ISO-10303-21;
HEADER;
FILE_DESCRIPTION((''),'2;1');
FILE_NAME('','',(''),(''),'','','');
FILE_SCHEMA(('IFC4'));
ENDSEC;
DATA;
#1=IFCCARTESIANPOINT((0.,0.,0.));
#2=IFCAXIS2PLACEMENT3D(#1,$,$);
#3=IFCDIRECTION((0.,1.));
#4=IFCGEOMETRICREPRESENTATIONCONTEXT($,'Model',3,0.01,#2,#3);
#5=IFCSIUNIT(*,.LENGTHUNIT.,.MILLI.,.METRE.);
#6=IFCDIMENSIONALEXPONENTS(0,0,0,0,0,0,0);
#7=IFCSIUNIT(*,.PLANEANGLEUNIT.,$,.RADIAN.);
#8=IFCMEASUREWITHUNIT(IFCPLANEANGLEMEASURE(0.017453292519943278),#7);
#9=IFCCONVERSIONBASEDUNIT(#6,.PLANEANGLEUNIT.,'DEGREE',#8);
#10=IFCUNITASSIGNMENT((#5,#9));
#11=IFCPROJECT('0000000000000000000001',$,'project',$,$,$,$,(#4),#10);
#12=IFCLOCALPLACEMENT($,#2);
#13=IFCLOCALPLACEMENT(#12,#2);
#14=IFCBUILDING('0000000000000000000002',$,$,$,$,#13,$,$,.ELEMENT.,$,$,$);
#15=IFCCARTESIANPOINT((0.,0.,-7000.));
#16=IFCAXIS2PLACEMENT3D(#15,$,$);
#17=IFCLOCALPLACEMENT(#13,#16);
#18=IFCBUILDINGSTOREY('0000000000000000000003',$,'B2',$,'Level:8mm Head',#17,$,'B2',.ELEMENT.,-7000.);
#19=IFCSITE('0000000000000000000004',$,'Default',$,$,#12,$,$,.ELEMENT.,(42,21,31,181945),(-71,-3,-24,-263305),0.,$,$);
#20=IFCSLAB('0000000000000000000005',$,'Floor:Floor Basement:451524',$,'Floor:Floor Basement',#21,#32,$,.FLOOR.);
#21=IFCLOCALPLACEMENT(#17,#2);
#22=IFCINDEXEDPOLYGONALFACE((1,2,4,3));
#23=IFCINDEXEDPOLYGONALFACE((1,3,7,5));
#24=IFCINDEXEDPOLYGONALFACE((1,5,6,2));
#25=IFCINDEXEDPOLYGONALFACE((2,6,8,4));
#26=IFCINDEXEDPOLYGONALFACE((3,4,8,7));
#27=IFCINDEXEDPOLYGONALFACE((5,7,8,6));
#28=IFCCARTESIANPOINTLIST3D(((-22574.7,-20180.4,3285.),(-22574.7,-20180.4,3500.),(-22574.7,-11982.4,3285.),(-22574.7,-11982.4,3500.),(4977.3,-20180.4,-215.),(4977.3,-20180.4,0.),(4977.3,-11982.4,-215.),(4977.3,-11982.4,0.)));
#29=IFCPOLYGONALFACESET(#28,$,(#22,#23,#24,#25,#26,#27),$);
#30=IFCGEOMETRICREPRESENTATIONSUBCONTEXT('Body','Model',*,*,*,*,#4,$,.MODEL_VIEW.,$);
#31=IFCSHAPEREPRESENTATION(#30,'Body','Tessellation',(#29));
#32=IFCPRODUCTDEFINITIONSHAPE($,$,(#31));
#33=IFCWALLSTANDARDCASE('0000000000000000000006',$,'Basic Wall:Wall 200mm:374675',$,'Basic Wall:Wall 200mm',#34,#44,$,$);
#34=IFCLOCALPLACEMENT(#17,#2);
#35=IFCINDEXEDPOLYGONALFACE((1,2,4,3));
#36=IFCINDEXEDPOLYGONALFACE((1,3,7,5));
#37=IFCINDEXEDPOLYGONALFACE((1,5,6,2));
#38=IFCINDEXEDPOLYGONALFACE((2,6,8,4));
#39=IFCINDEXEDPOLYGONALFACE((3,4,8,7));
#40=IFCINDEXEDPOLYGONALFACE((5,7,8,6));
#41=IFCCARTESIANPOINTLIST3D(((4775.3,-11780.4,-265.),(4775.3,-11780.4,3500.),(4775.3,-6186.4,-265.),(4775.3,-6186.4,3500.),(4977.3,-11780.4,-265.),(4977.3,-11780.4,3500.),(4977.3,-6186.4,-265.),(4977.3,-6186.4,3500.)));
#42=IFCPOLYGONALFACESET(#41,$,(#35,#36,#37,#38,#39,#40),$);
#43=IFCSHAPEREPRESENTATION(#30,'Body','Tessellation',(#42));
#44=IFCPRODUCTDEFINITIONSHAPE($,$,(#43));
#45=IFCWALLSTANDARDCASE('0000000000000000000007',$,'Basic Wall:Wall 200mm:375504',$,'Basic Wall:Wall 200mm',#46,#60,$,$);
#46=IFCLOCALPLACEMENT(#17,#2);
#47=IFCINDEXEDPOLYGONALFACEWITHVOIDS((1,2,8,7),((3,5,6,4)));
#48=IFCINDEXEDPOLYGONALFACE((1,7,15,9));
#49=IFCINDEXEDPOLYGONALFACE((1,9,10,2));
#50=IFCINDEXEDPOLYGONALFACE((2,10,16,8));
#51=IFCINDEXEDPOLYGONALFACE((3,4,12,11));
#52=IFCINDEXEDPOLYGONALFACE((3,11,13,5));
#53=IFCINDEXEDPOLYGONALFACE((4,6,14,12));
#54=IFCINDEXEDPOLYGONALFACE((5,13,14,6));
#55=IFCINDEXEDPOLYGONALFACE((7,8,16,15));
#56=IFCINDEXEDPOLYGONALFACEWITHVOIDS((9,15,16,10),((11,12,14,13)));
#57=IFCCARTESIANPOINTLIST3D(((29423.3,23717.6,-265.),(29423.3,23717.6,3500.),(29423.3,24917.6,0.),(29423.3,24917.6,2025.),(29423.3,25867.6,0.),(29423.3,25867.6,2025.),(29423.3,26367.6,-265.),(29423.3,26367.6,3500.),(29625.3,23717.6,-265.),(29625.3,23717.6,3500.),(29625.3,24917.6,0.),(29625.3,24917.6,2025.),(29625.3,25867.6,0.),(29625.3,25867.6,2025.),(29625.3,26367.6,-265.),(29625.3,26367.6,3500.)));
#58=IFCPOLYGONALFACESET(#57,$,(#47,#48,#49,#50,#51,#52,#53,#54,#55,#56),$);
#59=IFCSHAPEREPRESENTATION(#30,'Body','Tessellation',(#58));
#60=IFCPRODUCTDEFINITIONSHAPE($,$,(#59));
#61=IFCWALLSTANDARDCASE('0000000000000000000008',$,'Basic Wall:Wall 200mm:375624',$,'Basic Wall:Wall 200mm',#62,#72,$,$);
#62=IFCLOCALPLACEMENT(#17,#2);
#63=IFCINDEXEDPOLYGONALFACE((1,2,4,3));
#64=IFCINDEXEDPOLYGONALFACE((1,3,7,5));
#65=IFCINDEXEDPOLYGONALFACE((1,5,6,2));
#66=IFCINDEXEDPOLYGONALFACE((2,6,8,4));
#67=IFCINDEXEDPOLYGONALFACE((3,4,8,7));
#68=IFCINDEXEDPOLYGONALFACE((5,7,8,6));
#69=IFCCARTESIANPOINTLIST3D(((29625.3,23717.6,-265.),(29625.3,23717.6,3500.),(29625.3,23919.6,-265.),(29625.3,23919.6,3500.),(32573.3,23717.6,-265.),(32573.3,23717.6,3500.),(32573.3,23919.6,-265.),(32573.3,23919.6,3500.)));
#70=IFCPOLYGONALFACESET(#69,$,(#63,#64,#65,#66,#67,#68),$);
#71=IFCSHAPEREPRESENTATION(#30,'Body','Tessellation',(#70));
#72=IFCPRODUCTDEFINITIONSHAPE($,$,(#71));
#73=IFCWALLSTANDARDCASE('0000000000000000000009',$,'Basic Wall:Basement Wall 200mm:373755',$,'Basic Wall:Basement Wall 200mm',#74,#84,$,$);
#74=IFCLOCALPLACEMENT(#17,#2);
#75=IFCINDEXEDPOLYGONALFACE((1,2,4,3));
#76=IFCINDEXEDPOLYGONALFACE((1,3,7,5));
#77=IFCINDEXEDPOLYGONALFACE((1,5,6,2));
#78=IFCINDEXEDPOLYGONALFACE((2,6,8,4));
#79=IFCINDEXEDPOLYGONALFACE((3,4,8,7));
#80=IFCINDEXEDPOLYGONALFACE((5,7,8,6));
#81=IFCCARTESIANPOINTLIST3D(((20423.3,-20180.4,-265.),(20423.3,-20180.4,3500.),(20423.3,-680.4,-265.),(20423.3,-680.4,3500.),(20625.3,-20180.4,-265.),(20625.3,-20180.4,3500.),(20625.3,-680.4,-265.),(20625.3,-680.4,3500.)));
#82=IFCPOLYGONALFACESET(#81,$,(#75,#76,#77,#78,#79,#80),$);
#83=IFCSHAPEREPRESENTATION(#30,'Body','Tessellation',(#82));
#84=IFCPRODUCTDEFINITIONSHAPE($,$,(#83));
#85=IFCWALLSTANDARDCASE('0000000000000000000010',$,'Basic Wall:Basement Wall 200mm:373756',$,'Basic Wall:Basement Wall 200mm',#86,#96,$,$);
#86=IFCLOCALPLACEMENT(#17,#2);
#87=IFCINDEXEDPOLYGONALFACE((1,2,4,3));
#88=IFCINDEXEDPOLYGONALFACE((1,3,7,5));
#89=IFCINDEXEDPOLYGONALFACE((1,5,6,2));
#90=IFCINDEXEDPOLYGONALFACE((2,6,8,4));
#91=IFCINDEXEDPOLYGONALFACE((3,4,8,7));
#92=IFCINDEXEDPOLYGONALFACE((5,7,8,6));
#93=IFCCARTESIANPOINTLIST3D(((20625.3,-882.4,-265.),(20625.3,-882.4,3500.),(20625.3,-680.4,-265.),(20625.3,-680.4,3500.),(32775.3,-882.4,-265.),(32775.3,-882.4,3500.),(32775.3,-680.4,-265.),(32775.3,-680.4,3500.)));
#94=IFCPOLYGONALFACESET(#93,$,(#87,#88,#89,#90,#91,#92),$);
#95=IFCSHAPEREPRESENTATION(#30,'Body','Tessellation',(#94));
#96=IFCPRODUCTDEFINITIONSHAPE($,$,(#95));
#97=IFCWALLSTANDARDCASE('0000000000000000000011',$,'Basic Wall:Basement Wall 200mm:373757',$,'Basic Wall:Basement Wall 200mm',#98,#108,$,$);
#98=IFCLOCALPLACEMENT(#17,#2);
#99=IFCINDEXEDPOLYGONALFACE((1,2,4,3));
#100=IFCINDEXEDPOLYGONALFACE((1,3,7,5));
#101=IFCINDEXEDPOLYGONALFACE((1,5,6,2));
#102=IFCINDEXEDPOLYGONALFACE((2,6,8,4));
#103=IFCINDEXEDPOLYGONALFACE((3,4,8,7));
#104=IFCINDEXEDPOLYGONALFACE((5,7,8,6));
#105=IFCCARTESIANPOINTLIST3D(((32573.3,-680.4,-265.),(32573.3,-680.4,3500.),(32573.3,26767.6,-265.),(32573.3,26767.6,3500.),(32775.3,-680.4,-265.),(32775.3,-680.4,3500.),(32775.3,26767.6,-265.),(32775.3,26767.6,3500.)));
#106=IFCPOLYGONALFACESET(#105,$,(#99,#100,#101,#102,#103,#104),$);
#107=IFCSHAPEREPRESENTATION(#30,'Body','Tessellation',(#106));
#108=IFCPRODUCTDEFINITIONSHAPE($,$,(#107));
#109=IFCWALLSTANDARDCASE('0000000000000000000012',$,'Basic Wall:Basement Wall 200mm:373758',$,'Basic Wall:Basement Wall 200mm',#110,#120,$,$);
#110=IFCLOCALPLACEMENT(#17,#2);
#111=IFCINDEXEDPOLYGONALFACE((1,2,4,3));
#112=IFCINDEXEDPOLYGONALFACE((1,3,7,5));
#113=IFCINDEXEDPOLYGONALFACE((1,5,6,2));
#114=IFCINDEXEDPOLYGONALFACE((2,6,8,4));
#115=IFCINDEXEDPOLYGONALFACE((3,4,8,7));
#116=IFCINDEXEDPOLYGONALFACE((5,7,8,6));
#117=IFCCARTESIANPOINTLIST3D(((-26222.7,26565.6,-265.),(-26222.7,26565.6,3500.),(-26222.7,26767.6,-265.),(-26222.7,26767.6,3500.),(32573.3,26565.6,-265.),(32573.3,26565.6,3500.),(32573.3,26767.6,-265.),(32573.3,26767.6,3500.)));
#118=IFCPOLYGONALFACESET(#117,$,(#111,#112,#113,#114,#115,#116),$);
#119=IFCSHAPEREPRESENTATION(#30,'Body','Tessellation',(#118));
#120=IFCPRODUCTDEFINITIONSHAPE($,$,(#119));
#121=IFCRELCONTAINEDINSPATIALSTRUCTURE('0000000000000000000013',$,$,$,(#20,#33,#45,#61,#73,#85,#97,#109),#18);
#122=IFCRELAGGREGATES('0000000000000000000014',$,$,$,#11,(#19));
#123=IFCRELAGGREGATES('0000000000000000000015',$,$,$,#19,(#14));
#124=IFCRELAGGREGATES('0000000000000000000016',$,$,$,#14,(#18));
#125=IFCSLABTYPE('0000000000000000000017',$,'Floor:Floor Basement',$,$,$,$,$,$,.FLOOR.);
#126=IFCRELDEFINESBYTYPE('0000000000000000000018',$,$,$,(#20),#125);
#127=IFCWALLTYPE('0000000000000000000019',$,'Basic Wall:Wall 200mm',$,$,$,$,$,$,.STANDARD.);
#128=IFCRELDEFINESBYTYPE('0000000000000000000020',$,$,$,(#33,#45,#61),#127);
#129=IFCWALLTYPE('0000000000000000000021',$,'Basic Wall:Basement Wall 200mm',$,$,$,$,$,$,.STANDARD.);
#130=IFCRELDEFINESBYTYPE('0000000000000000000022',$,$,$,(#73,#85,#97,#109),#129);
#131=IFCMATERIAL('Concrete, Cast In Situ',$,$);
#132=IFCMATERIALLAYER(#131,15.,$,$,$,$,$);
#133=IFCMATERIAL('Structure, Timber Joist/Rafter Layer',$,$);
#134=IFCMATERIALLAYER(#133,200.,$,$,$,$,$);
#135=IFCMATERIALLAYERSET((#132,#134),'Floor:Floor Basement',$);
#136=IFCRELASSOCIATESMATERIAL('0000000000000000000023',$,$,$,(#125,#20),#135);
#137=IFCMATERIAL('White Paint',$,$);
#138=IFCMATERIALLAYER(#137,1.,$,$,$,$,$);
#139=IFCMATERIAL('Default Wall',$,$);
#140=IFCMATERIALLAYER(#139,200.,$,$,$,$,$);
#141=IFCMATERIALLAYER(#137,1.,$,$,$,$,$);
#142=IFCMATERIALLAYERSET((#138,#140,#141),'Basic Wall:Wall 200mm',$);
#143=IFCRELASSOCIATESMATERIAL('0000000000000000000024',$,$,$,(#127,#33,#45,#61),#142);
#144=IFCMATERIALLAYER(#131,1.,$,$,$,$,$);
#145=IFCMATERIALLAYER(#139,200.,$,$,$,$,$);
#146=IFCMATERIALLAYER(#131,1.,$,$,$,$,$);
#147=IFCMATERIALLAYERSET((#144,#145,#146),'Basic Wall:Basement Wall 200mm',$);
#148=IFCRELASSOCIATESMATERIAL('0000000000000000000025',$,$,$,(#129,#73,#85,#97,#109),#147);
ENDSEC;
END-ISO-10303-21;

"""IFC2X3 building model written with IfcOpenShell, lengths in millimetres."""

from ifc_helpers import new_model, entity, si_unit, converted_unit, direction, frame, frame_2d, origin, place, context, subcontext, project, spatial, rectangle, extrude, clip, halfspace, material, layer, layer_set, layer_usage, type_object, element, save


model = new_model("IFC2X3")

# Units and contexts
model_context = context("Model", 3, precision=0.01, world=origin(), true_north=direction((0.0, 1.0)))
body_context = subcontext(model_context, "Body", "Model", "MODEL_VIEW")
ifc_project = project(units=[si_unit("LENGTHUNIT", "METRE", prefix="MILLI"), converted_unit("PLANEANGLEUNIT", "DEGREE", entity("IfcPlaneAngleMeasure", 0.017453292519943278), si_unit("PLANEANGLEUNIT", "RADIAN"), dimensions=[0, 0, 0, 0, 0, 0, 0])], contexts=[model_context])

# Site, building, storey
site_placement = place(None, origin())
site = spatial("IfcSite", under=ifc_project, at=site_placement, Name="Default", CompositionType="ELEMENT", RefLatitude=(42, 21, 31, 181945), RefLongitude=(-71, -3, -24, -263305), RefElevation=0.0)
building_placement = place(site_placement, origin())
building = spatial("IfcBuilding", under=site, at=building_placement, CompositionType="ELEMENT")
storey_placement = place(building_placement, frame((0.0, 0.0, -7000.0)))
storey = spatial("IfcBuildingStorey", under=building, at=storey_placement, Name="B2", ObjectType="Level:8mm Head", LongName="B2", CompositionType="ELEMENT", Elevation=-7000.0)

# Shared definitions
ifc_material_1 = material(Name="White Paint")

# Slab
ifc_material_2 = material(Name="Concrete, Cast In Situ")
ifc_layer_1 = layer(ifc_material_2, 15.0)
ifc_material_3 = material(Name="Structure, Timber Joist/Rafter Layer")
ifc_layer_2 = layer(ifc_material_3, 200.0)
ifc_layer_set_1 = layer_set([ifc_layer_1, ifc_layer_2], Name="Floor:Floor Basement")
ifc_layer_usage_1 = layer_usage(ifc_layer_set_1, "AXIS3", "POSITIVE", 0.0)
slab_type = type_object("IfcSlabType", Name="Floor:Floor Basement", PredefinedType="FLOOR", material=ifc_layer_set_1)
slab_placement = place(storey_placement, origin())
element("IfcSlab", 1, at=slab_placement, inside=storey, type_object=slab_type, material=ifc_layer_usage_1, Name="Floor:Floor Basement:451524", ObjectType="Floor:Floor Basement", PredefinedType="FLOOR", context=body_context, shape_type="SweptSolid", body=[
    clip(clip(extrude(rectangle(XDim=27773.4, YDim=8198.0, at=frame_2d((0.0, 0.0), x_axis=(0.0, 1.0))), frame((-8798.7, -16081.4, 1750.0), z_axis=(-0.12602, 0.0, -0.992028), x_axis=(0.0, 1.0, 0.0)), (0.0, 0.12602, 0.992028), 216.7), halfspace(frame((-8798.7, -16081.4, 1535.0), z_axis=(-0.12602, 0.0, -0.992028), x_axis=(0.0, -1.0, 0.0)), False)), halfspace(frame((-8798.7, -16081.4, 1750.0), z_axis=(0.12602, 0.0, 0.992028), x_axis=(0.0, -1.0, 0.0)), False)),
])

# Wall
ifc_layer_3 = layer(ifc_material_1, 1.0)
ifc_material_4 = material(Name="Default Wall")
ifc_layer_4 = layer(ifc_material_4, 200.0)
ifc_layer_5 = layer(ifc_material_1, 1.0)
ifc_layer_set_2 = layer_set([ifc_layer_3, ifc_layer_4, ifc_layer_5], Name="Basic Wall:Wall 200mm")
ifc_layer_usage_2 = layer_usage(ifc_layer_set_2, "AXIS2", "NEGATIVE", 101.0)
wall_type_1 = type_object("IfcWallType", Name="Basic Wall:Wall 200mm", PredefinedType="STANDARD", material=ifc_layer_set_2)
wall_1_placement = place(storey_placement, frame((4876.3, -6186.4, -265.0), z_axis=(0.0, 0.0, 1.0), x_axis=(0.0, -1.0, 0.0)))
element("IfcWallStandardCase", 2, at=wall_1_placement, inside=storey, type_object=wall_type_1, material=ifc_layer_usage_2, Name="Basic Wall:Wall 200mm:374675", ObjectType="Basic Wall:Wall 200mm", context=body_context, shape_type="SweptSolid", body=[
    extrude(rectangle(XDim=5594.0, YDim=202.0, at=frame_2d((2797.0, 0.0), x_axis=(-1.0, 0.0))), origin(), (0.0, 0.0, 1.0), 3765.0),
])

# Wall, openings
ifc_layer_usage_3 = layer_usage(ifc_layer_set_2, "AXIS2", "NEGATIVE", 101.0)
wall_2_placement = place(storey_placement, frame((29524.3, 26367.6, -265.0), z_axis=(0.0, 0.0, 1.0), x_axis=(0.0, -1.0, 0.0)))
wall_2 = element("IfcWallStandardCase", 3, at=wall_2_placement, inside=storey, type_object=wall_type_1, material=ifc_layer_usage_3, Name="Basic Wall:Wall 200mm:375504", ObjectType="Basic Wall:Wall 200mm", context=body_context, shape_type="SweptSolid", body=[
    extrude(rectangle(XDim=2650.0, YDim=202.0, at=frame_2d((1325.0, 0.0), x_axis=(-1.0, 0.0))), origin(), (0.0, 0.0, 1.0), 3765.0),
])
opening_1_placement = place(wall_2_placement, origin())
element("IfcOpeningElement", 4, at=opening_1_placement, cuts=wall_2, ObjectType="Opening", context=body_context, shape_type="SweptSolid", body=[
    extrude(rectangle(XDim=2025.0, YDim=950.0, at=frame_2d((0.0, 0.0), x_axis=(0.0, 1.0))), frame((975.0, -1625.0, 4777.5), z_axis=(0.0, 1.0, 0.0), x_axis=(-1.0, 0.0, 0.0)), (0.0, 0.0, 1.0), 3048.0),
])
opening_2_placement = place(wall_2_placement, frame((500.0, -101.0, 265.0)))
element("IfcOpeningElement", 5, at=opening_2_placement, cuts=wall_2, ObjectType="Opening", context=body_context, shape_type="SweptSolid", body=[
    extrude(rectangle(XDim=2025.0, YDim=950.0, at=frame_2d((1012.5, 475.0), x_axis=(1.0, 0.0))), frame((0.0, 0.0, 0.0), z_axis=(0.0, 1.0, 0.0), x_axis=(0.0, 0.0, 1.0)), (0.0, 0.0, 1.0), 202.0),
])

# Walls
ifc_layer_usage_4 = layer_usage(ifc_layer_set_2, "AXIS2", "POSITIVE", -101.0)
wall_3_placement = place(storey_placement, frame((29625.3, 23818.6, -265.0)))
element("IfcWallStandardCase", 6, at=wall_3_placement, inside=storey, type_object=wall_type_1, material=ifc_layer_usage_4, Name="Basic Wall:Wall 200mm:375624", ObjectType="Basic Wall:Wall 200mm", context=body_context, shape_type="SweptSolid", body=[
    extrude(rectangle(XDim=2948.0, YDim=202.0, at=frame_2d((1474.0, 0.0), x_axis=(-1.0, 0.0))), origin(), (0.0, 0.0, 1.0), 3765.0),
])
ifc_layer_6 = layer(ifc_material_2, 1.0)
ifc_layer_7 = layer(ifc_material_4, 200.0)
ifc_layer_8 = layer(ifc_material_2, 1.0)
ifc_layer_set_3 = layer_set([ifc_layer_6, ifc_layer_7, ifc_layer_8], Name="Basic Wall:Basement Wall 200mm")
ifc_layer_usage_5 = layer_usage(ifc_layer_set_3, "AXIS2", "POSITIVE", -101.0)
wall_type_2 = type_object("IfcWallType", Name="Basic Wall:Basement Wall 200mm", PredefinedType="STANDARD", material=ifc_layer_set_3)
wall_4_placement = place(storey_placement, frame((20524.3, -20180.4, -265.0), z_axis=(0.0, 0.0, 1.0), x_axis=(0.0, 1.0, 0.0)))
element("IfcWallStandardCase", 7, at=wall_4_placement, inside=storey, type_object=wall_type_2, material=ifc_layer_usage_5, Name="Basic Wall:Basement Wall 200mm:373755", ObjectType="Basic Wall:Basement Wall 200mm", context=body_context, shape_type="SweptSolid", body=[
    extrude(rectangle(XDim=19500.0, YDim=202.0, at=frame_2d((9750.0, 0.0), x_axis=(-1.0, 0.0))), origin(), (0.0, 0.0, 1.0), 3765.0),
])
ifc_layer_usage_6 = layer_usage(ifc_layer_set_3, "AXIS2", "POSITIVE", -101.0)
wall_5_placement = place(storey_placement, frame((20625.3, -781.4, -265.0)))
element("IfcWallStandardCase", 8, at=wall_5_placement, inside=storey, type_object=wall_type_2, material=ifc_layer_usage_6, Name="Basic Wall:Basement Wall 200mm:373756", ObjectType="Basic Wall:Basement Wall 200mm", context=body_context, shape_type="SweptSolid", body=[
    extrude(rectangle(XDim=12150.0, YDim=202.0, at=frame_2d((6075.0, 0.0), x_axis=(-1.0, 0.0))), origin(), (0.0, 0.0, 1.0), 3765.0),
])
ifc_layer_usage_7 = layer_usage(ifc_layer_set_3, "AXIS2", "POSITIVE", -101.0)
wall_6_placement = place(storey_placement, frame((32674.3, -680.4, -265.0), z_axis=(0.0, 0.0, 1.0), x_axis=(0.0, 1.0, 0.0)))
element("IfcWallStandardCase", 9, at=wall_6_placement, inside=storey, type_object=wall_type_2, material=ifc_layer_usage_7, Name="Basic Wall:Basement Wall 200mm:373757", ObjectType="Basic Wall:Basement Wall 200mm", context=body_context, shape_type="SweptSolid", body=[
    extrude(rectangle(XDim=27448.0, YDim=202.0, at=frame_2d((13724.0, 0.0), x_axis=(-1.0, 0.0))), origin(), (0.0, 0.0, 1.0), 3765.0),
])
ifc_layer_usage_8 = layer_usage(ifc_layer_set_3, "AXIS2", "POSITIVE", -101.0)
wall_7_placement = place(storey_placement, frame((32573.3, 26666.6, -265.0), z_axis=(0.0, 0.0, 1.0), x_axis=(-1.0, 0.0, 0.0)))
element("IfcWallStandardCase", 10, at=wall_7_placement, inside=storey, type_object=wall_type_2, material=ifc_layer_usage_8, Name="Basic Wall:Basement Wall 200mm:373758", ObjectType="Basic Wall:Basement Wall 200mm", context=body_context, shape_type="SweptSolid", body=[
    extrude(rectangle(XDim=58796.0, YDim=202.0, at=frame_2d((29398.0, 0.0), x_axis=(-1.0, 0.0))), origin(), (0.0, 0.0, 1.0), 3765.0),
])

save(model, "model.ifc")
